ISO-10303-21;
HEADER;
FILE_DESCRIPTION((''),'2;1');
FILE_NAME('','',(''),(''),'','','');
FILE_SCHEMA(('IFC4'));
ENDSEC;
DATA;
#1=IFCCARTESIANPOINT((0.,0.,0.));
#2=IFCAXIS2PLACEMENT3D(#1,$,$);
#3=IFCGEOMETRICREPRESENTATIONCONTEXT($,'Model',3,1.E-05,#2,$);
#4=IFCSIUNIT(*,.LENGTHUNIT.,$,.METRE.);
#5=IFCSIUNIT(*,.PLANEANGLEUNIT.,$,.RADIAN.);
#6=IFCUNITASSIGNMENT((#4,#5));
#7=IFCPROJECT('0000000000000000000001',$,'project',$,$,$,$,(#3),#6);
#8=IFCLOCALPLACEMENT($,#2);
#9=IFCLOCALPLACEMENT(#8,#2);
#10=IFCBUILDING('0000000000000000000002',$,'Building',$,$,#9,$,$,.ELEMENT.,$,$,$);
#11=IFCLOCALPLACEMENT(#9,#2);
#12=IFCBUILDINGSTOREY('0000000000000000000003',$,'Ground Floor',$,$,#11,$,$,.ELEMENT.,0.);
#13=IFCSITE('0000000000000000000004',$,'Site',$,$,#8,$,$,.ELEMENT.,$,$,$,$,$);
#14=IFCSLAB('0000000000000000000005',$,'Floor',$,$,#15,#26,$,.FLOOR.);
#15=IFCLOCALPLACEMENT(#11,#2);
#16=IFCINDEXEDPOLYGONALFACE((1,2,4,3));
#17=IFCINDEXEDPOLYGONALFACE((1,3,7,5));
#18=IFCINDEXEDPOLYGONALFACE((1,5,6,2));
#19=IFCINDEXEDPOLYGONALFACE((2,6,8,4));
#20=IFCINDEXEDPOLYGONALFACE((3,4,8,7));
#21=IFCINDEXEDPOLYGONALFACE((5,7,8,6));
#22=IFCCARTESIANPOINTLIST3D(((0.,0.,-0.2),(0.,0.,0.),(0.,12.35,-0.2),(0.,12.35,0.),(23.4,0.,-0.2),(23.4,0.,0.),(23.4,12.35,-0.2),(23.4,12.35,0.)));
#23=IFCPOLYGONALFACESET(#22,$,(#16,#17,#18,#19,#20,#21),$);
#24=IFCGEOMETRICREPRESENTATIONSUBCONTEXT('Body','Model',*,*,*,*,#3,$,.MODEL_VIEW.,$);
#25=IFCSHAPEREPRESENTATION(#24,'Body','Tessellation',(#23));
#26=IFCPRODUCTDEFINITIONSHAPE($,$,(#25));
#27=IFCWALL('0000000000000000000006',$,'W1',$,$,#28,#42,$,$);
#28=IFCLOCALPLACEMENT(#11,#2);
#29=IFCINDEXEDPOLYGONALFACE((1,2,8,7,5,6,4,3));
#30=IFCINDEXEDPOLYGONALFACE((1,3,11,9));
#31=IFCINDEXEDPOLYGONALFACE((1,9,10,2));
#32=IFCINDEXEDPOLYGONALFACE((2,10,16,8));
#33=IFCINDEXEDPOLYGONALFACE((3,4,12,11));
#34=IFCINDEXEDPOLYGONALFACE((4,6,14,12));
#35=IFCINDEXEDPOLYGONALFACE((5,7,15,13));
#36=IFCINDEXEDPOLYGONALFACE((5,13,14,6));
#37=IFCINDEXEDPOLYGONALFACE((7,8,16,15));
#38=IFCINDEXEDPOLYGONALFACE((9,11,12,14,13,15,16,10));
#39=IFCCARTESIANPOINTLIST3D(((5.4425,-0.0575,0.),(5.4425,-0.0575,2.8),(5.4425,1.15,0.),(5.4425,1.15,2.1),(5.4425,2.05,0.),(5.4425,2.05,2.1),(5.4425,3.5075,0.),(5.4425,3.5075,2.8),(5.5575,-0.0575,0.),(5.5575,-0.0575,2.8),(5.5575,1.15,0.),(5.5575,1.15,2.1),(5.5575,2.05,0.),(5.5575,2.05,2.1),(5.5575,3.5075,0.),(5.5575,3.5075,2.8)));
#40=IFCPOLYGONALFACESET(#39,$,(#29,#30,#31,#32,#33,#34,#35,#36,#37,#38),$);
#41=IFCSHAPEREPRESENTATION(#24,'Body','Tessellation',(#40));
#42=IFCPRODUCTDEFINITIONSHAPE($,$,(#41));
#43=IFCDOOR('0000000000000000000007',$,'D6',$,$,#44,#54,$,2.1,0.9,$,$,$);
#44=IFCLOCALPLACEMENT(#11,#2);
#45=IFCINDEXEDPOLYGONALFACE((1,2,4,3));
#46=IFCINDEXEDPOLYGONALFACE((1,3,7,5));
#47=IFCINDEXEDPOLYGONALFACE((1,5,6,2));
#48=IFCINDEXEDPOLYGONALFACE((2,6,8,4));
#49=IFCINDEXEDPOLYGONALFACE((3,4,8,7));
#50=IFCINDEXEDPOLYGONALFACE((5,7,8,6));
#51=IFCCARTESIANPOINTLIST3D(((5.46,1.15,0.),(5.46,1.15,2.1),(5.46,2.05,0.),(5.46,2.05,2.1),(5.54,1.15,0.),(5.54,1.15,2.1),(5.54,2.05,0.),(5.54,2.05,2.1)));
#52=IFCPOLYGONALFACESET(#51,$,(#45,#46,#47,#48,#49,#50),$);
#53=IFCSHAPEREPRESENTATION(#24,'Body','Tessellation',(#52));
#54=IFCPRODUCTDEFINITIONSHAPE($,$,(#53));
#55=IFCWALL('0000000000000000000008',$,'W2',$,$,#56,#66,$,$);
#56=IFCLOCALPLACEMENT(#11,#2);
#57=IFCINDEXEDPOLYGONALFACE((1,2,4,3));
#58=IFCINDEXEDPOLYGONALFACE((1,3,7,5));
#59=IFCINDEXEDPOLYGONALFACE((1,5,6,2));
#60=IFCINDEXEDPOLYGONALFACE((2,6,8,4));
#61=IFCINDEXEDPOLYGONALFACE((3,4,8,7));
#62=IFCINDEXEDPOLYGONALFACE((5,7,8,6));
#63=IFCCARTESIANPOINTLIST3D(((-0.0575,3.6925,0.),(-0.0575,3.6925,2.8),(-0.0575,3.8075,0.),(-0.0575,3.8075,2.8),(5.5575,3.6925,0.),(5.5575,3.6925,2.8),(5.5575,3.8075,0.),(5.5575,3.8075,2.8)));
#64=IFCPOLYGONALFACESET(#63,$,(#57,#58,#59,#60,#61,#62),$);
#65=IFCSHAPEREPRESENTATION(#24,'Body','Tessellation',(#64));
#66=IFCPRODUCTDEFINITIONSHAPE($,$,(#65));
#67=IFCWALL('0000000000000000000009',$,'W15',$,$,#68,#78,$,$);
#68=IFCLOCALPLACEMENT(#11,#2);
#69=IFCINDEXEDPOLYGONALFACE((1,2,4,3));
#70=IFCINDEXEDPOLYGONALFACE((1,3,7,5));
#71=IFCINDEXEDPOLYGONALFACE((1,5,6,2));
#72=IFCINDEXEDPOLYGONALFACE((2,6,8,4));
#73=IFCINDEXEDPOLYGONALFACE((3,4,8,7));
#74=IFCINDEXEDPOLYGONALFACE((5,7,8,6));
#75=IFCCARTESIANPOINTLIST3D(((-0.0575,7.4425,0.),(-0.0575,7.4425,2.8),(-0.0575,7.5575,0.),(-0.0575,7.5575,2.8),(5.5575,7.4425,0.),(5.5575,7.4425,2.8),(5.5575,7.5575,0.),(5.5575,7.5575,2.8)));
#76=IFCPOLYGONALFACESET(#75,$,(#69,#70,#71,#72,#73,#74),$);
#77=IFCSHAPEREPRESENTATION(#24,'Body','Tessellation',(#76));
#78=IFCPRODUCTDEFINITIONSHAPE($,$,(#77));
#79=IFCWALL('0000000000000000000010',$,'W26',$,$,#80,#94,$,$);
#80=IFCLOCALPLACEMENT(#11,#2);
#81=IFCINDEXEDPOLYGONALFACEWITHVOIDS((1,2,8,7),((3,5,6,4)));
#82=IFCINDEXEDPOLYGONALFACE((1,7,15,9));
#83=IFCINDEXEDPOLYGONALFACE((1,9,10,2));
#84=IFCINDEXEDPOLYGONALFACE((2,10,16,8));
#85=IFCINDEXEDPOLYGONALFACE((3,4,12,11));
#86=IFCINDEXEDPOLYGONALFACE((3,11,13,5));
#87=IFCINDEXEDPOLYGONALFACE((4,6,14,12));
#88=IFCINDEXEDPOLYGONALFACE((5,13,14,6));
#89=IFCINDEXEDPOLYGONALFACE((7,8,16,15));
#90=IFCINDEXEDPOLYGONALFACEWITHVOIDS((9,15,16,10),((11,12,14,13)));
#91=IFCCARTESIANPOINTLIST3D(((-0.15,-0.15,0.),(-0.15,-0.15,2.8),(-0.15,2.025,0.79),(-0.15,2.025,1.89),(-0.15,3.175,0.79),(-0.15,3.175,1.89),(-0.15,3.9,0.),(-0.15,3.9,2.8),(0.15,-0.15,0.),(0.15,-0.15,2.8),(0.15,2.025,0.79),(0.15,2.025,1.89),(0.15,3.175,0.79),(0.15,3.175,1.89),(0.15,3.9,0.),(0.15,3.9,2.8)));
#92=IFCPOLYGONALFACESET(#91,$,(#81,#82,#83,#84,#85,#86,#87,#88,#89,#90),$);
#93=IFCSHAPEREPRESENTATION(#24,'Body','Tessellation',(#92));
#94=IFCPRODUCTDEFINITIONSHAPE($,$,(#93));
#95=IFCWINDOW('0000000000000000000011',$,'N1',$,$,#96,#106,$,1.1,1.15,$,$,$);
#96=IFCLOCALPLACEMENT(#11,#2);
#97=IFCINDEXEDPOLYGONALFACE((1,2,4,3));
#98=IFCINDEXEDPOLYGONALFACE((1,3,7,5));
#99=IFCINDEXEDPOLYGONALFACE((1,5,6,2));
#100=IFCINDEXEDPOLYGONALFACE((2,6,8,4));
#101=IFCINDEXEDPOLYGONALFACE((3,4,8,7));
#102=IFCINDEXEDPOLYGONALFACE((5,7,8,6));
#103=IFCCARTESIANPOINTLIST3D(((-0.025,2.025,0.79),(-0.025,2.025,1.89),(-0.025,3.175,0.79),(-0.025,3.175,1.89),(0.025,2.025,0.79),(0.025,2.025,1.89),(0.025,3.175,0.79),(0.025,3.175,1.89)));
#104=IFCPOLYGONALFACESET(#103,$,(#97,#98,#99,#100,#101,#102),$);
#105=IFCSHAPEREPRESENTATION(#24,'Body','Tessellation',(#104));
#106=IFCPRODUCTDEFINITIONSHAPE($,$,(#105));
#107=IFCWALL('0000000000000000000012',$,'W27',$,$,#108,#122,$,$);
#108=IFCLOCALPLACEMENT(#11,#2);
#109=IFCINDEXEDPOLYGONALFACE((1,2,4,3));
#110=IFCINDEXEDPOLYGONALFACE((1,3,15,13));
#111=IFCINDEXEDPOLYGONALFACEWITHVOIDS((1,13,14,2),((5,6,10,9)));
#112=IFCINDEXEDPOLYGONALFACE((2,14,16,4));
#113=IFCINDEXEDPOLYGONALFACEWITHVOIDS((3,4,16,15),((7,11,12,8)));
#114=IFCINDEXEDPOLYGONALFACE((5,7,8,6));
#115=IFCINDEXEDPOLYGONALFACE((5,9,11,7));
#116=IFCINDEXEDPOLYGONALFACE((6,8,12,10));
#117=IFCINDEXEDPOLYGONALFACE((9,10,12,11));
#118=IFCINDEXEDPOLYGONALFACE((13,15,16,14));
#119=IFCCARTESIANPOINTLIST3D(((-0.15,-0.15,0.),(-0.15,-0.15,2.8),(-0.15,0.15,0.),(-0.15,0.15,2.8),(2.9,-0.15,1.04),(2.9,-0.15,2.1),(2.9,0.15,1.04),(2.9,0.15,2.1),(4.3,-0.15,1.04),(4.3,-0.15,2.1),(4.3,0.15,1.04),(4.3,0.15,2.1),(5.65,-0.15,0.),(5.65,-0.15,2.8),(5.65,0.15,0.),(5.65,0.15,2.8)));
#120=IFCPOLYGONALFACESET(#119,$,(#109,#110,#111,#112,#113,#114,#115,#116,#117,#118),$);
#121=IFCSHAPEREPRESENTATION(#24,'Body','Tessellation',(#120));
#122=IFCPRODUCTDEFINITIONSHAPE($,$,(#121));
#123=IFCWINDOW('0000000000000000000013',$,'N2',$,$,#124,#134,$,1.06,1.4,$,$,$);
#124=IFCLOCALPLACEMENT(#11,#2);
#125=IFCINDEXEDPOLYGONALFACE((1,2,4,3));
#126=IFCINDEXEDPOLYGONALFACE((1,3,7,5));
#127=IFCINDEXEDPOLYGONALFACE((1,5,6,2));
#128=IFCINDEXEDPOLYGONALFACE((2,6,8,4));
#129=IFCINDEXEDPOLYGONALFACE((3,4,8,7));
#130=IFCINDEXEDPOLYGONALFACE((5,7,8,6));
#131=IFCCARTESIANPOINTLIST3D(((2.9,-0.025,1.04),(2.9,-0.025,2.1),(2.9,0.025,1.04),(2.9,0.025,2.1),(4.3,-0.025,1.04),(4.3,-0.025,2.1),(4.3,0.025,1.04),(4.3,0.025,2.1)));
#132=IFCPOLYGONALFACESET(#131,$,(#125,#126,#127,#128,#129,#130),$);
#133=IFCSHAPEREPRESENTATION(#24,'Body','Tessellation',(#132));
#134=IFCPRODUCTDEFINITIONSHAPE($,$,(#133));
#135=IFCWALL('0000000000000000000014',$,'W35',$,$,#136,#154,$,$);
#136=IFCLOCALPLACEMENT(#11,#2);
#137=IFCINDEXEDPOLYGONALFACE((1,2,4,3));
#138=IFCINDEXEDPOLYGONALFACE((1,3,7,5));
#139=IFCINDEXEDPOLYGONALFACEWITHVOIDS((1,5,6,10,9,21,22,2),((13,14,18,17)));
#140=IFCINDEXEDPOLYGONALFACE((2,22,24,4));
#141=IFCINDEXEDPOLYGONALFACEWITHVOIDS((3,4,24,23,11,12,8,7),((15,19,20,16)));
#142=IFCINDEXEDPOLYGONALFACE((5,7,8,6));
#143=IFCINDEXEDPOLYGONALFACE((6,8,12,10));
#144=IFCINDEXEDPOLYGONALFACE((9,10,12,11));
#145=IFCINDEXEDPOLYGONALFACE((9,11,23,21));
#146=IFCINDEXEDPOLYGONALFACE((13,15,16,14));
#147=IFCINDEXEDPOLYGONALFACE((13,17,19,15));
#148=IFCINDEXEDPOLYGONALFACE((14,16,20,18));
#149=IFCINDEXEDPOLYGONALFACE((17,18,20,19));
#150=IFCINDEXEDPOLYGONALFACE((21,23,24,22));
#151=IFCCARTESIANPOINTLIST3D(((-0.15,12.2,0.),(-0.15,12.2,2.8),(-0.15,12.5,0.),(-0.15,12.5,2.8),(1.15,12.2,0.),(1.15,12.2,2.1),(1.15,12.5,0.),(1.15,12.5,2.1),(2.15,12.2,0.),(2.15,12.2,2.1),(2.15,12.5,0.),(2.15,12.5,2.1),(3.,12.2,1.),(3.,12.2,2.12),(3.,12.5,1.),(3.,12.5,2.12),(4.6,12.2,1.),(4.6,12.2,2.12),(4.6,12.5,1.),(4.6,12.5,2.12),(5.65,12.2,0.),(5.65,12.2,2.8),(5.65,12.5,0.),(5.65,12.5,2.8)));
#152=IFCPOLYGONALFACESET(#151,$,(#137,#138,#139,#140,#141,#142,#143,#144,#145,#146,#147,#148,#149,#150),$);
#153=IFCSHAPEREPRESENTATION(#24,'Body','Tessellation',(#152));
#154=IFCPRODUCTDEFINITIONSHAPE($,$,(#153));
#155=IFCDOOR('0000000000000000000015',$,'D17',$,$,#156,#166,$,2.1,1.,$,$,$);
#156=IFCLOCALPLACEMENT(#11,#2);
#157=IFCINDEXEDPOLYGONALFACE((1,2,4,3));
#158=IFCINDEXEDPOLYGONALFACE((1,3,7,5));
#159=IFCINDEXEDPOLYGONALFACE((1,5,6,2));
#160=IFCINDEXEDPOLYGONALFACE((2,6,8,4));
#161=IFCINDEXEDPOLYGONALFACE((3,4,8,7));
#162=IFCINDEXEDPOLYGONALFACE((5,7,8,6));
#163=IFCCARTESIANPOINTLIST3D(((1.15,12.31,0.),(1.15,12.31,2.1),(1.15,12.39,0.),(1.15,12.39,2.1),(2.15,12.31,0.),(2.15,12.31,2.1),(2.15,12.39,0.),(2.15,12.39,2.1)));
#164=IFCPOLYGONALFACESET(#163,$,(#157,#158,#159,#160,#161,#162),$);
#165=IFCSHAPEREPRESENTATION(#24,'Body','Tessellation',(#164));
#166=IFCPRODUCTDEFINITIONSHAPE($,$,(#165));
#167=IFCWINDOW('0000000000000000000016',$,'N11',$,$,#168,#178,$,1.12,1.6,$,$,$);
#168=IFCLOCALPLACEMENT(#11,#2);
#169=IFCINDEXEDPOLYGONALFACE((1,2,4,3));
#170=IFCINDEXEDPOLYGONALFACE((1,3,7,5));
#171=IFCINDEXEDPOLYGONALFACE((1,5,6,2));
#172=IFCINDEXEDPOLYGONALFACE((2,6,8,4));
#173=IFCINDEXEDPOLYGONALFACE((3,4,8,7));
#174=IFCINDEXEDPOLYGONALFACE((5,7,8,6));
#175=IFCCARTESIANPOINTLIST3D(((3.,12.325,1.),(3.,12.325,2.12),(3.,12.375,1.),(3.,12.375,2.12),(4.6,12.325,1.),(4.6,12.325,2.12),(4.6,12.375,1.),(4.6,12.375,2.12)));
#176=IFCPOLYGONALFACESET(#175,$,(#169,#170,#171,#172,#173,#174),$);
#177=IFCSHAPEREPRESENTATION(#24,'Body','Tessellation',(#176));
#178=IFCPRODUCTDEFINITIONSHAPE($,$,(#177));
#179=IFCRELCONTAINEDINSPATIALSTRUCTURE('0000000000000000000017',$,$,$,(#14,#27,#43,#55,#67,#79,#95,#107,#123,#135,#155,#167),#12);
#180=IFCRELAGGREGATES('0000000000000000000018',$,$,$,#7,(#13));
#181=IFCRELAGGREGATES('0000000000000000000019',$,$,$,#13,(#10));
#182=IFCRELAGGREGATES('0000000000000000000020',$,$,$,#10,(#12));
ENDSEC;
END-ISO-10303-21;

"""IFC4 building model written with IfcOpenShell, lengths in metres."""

from ifc_helpers import new_model, si_unit, frame, frame_2d, origin, origin_2d, place, context, subcontext, project, spatial, polyline, rectangle, outline, extrude, element, fill, save


model = new_model("IFC4")

# Units and contexts
model_context = context("Model", 3, precision=1e-05, world=origin())
body_context = subcontext(model_context, "Body", "Model", "MODEL_VIEW")
ifc_project = project(units=[si_unit("LENGTHUNIT", "METRE"), si_unit("PLANEANGLEUNIT", "RADIAN")], contexts=[model_context])

# Site, building, storey
site_placement = place(None, origin())
site = spatial("IfcSite", under=ifc_project, at=site_placement, Name="Site", CompositionType="ELEMENT")
building_placement = place(site_placement, origin())
building = spatial("IfcBuilding", under=site, at=building_placement, Name="Building", CompositionType="ELEMENT")
storey_placement = place(building_placement, origin())
storey = spatial("IfcBuildingStorey", under=building, at=storey_placement, Name="Ground Floor", CompositionType="ELEMENT", Elevation=0.0)

# Slab
slab_placement = place(storey_placement, origin())
element("IfcSlab", 1, at=slab_placement, inside=storey, Name="Floor", PredefinedType="FLOOR", context=body_context, shape_type="SweptSolid", body=[
    extrude(outline(polyline([(0.0, 0.0), (23.4, 0.0), (23.4, 12.35), (0.0, 12.35), (0.0, 0.0)])), origin(), (0.0, 0.0, -1.0), 0.2),
])

# Wall, opening, door
wall_1_placement = place(storey_placement, frame((5.5, 0.0, 0.0), x_axis=(0.0, 1.0, 0.0)))
wall_1 = element("IfcWall", 2, at=wall_1_placement, inside=storey, Name="W1", context=body_context, shape_type="SweptSolid", body=[
    extrude(rectangle(XDim=3.565, YDim=0.115, at=frame_2d((1.725, 0.0))), origin(), (0.0, 0.0, 1.0), 2.8),
])
opening_1_placement = place(wall_1_placement, frame((1.6, 0.0, 0.0)))
opening_1 = element("IfcOpeningElement", 3, at=opening_1_placement, cuts=wall_1, context=body_context, shape_type="SweptSolid", body=[
    extrude(rectangle(XDim=0.9, YDim=0.215, at=origin_2d()), origin(), (0.0, 0.0, 1.0), 2.1),
])
door_1_placement = place(opening_1_placement, origin())
door_1 = element("IfcDoor", 4, at=door_1_placement, inside=storey, Name="D6", OverallHeight=2.1, OverallWidth=0.9, context=body_context, shape_type="SweptSolid", body=[
    extrude(rectangle(XDim=0.9, YDim=0.08, at=origin_2d()), origin(), (0.0, 0.0, 1.0), 2.1),
])
fill(opening_1, door_1)

# Walls
wall_2_placement = place(storey_placement, frame((0.0, 3.75, 0.0), x_axis=(1.0, 0.0, 0.0)))
element("IfcWall", 5, at=wall_2_placement, inside=storey, Name="W2", context=body_context, shape_type="SweptSolid", body=[
    extrude(rectangle(XDim=5.615, YDim=0.115, at=frame_2d((2.75, 0.0))), origin(), (0.0, 0.0, 1.0), 2.8),
])
wall_3_placement = place(storey_placement, frame((0.0, 7.5, 0.0), x_axis=(1.0, 0.0, 0.0)))
element("IfcWall", 6, at=wall_3_placement, inside=storey, Name="W15", context=body_context, shape_type="SweptSolid", body=[
    extrude(rectangle(XDim=5.615, YDim=0.115, at=frame_2d((2.75, 0.0))), origin(), (0.0, 0.0, 1.0), 2.8),
])

# Walls, openings, windows
wall_4_placement = place(storey_placement, frame((0.0, 0.0, 0.0), x_axis=(0.0, 1.0, 0.0)))
wall_4 = element("IfcWall", 7, at=wall_4_placement, inside=storey, Name="W26", context=body_context, shape_type="SweptSolid", body=[
    extrude(rectangle(XDim=4.05, YDim=0.3, at=frame_2d((1.875, 0.0))), origin(), (0.0, 0.0, 1.0), 2.8),
])
opening_2_placement = place(wall_4_placement, frame((2.6, 0.0, 0.79)))
opening_2 = element("IfcOpeningElement", 8, at=opening_2_placement, cuts=wall_4, context=body_context, shape_type="SweptSolid", body=[
    extrude(rectangle(XDim=1.15, YDim=0.4, at=origin_2d()), origin(), (0.0, 0.0, 1.0), 1.1),
])
window_1_placement = place(opening_2_placement, origin())
window_1 = element("IfcWindow", 9, at=window_1_placement, inside=storey, Name="N1", OverallHeight=1.1, OverallWidth=1.15, context=body_context, shape_type="SweptSolid", body=[
    extrude(rectangle(XDim=1.15, YDim=0.05, at=origin_2d()), origin(), (0.0, 0.0, 1.0), 1.1),
])
fill(opening_2, window_1)
wall_5_placement = place(storey_placement, frame((0.0, 0.0, 0.0), x_axis=(1.0, 0.0, 0.0)))
wall_5 = element("IfcWall", 10, at=wall_5_placement, inside=storey, Name="W27", context=body_context, shape_type="SweptSolid", body=[
    extrude(rectangle(XDim=5.8, YDim=0.3, at=frame_2d((2.75, 0.0))), origin(), (0.0, 0.0, 1.0), 2.8),
])
opening_3_placement = place(wall_5_placement, frame((3.6, 0.0, 1.04)))
opening_3 = element("IfcOpeningElement", 11, at=opening_3_placement, cuts=wall_5, context=body_context, shape_type="SweptSolid", body=[
    extrude(rectangle(XDim=1.4, YDim=0.4, at=origin_2d()), origin(), (0.0, 0.0, 1.0), 1.06),
])
window_2_placement = place(opening_3_placement, origin())
window_2 = element("IfcWindow", 12, at=window_2_placement, inside=storey, Name="N2", OverallHeight=1.06, OverallWidth=1.4, context=body_context, shape_type="SweptSolid", body=[
    extrude(rectangle(XDim=1.4, YDim=0.05, at=origin_2d()), origin(), (0.0, 0.0, 1.0), 1.06),
])
fill(opening_3, window_2)

# Wall, openings, door, window
wall_6_placement = place(storey_placement, frame((0.0, 12.35, 0.0), x_axis=(1.0, 0.0, 0.0)))
wall_6 = element("IfcWall", 13, at=wall_6_placement, inside=storey, Name="W35", context=body_context, shape_type="SweptSolid", body=[
    extrude(rectangle(XDim=5.8, YDim=0.3, at=frame_2d((2.75, 0.0))), origin(), (0.0, 0.0, 1.0), 2.8),
])
opening_4_placement = place(wall_6_placement, frame((1.65, 0.0, 0.0)))
opening_4 = element("IfcOpeningElement", 14, at=opening_4_placement, cuts=wall_6, context=body_context, shape_type="SweptSolid", body=[
    extrude(rectangle(XDim=1.0, YDim=0.4, at=origin_2d()), origin(), (0.0, 0.0, 1.0), 2.1),
])
opening_5_placement = place(wall_6_placement, frame((3.8, 0.0, 1.0)))
opening_5 = element("IfcOpeningElement", 15, at=opening_5_placement, cuts=wall_6, context=body_context, shape_type="SweptSolid", body=[
    extrude(rectangle(XDim=1.6, YDim=0.4, at=origin_2d()), origin(), (0.0, 0.0, 1.0), 1.12),
])
door_2_placement = place(opening_4_placement, origin())
door_2 = element("IfcDoor", 16, at=door_2_placement, inside=storey, Name="D17", OverallHeight=2.1, OverallWidth=1.0, context=body_context, shape_type="SweptSolid", body=[
    extrude(rectangle(XDim=1.0, YDim=0.08, at=origin_2d()), origin(), (0.0, 0.0, 1.0), 2.1),
])
fill(opening_4, door_2)
window_3_placement = place(opening_5_placement, origin())
window_3 = element("IfcWindow", 17, at=window_3_placement, inside=storey, Name="N11", OverallHeight=1.12, OverallWidth=1.6, context=body_context, shape_type="SweptSolid", body=[
    extrude(rectangle(XDim=1.6, YDim=0.05, at=origin_2d()), origin(), (0.0, 0.0, 1.0), 1.12),
])
fill(opening_5, window_3)

save(model, "model.ifc")
